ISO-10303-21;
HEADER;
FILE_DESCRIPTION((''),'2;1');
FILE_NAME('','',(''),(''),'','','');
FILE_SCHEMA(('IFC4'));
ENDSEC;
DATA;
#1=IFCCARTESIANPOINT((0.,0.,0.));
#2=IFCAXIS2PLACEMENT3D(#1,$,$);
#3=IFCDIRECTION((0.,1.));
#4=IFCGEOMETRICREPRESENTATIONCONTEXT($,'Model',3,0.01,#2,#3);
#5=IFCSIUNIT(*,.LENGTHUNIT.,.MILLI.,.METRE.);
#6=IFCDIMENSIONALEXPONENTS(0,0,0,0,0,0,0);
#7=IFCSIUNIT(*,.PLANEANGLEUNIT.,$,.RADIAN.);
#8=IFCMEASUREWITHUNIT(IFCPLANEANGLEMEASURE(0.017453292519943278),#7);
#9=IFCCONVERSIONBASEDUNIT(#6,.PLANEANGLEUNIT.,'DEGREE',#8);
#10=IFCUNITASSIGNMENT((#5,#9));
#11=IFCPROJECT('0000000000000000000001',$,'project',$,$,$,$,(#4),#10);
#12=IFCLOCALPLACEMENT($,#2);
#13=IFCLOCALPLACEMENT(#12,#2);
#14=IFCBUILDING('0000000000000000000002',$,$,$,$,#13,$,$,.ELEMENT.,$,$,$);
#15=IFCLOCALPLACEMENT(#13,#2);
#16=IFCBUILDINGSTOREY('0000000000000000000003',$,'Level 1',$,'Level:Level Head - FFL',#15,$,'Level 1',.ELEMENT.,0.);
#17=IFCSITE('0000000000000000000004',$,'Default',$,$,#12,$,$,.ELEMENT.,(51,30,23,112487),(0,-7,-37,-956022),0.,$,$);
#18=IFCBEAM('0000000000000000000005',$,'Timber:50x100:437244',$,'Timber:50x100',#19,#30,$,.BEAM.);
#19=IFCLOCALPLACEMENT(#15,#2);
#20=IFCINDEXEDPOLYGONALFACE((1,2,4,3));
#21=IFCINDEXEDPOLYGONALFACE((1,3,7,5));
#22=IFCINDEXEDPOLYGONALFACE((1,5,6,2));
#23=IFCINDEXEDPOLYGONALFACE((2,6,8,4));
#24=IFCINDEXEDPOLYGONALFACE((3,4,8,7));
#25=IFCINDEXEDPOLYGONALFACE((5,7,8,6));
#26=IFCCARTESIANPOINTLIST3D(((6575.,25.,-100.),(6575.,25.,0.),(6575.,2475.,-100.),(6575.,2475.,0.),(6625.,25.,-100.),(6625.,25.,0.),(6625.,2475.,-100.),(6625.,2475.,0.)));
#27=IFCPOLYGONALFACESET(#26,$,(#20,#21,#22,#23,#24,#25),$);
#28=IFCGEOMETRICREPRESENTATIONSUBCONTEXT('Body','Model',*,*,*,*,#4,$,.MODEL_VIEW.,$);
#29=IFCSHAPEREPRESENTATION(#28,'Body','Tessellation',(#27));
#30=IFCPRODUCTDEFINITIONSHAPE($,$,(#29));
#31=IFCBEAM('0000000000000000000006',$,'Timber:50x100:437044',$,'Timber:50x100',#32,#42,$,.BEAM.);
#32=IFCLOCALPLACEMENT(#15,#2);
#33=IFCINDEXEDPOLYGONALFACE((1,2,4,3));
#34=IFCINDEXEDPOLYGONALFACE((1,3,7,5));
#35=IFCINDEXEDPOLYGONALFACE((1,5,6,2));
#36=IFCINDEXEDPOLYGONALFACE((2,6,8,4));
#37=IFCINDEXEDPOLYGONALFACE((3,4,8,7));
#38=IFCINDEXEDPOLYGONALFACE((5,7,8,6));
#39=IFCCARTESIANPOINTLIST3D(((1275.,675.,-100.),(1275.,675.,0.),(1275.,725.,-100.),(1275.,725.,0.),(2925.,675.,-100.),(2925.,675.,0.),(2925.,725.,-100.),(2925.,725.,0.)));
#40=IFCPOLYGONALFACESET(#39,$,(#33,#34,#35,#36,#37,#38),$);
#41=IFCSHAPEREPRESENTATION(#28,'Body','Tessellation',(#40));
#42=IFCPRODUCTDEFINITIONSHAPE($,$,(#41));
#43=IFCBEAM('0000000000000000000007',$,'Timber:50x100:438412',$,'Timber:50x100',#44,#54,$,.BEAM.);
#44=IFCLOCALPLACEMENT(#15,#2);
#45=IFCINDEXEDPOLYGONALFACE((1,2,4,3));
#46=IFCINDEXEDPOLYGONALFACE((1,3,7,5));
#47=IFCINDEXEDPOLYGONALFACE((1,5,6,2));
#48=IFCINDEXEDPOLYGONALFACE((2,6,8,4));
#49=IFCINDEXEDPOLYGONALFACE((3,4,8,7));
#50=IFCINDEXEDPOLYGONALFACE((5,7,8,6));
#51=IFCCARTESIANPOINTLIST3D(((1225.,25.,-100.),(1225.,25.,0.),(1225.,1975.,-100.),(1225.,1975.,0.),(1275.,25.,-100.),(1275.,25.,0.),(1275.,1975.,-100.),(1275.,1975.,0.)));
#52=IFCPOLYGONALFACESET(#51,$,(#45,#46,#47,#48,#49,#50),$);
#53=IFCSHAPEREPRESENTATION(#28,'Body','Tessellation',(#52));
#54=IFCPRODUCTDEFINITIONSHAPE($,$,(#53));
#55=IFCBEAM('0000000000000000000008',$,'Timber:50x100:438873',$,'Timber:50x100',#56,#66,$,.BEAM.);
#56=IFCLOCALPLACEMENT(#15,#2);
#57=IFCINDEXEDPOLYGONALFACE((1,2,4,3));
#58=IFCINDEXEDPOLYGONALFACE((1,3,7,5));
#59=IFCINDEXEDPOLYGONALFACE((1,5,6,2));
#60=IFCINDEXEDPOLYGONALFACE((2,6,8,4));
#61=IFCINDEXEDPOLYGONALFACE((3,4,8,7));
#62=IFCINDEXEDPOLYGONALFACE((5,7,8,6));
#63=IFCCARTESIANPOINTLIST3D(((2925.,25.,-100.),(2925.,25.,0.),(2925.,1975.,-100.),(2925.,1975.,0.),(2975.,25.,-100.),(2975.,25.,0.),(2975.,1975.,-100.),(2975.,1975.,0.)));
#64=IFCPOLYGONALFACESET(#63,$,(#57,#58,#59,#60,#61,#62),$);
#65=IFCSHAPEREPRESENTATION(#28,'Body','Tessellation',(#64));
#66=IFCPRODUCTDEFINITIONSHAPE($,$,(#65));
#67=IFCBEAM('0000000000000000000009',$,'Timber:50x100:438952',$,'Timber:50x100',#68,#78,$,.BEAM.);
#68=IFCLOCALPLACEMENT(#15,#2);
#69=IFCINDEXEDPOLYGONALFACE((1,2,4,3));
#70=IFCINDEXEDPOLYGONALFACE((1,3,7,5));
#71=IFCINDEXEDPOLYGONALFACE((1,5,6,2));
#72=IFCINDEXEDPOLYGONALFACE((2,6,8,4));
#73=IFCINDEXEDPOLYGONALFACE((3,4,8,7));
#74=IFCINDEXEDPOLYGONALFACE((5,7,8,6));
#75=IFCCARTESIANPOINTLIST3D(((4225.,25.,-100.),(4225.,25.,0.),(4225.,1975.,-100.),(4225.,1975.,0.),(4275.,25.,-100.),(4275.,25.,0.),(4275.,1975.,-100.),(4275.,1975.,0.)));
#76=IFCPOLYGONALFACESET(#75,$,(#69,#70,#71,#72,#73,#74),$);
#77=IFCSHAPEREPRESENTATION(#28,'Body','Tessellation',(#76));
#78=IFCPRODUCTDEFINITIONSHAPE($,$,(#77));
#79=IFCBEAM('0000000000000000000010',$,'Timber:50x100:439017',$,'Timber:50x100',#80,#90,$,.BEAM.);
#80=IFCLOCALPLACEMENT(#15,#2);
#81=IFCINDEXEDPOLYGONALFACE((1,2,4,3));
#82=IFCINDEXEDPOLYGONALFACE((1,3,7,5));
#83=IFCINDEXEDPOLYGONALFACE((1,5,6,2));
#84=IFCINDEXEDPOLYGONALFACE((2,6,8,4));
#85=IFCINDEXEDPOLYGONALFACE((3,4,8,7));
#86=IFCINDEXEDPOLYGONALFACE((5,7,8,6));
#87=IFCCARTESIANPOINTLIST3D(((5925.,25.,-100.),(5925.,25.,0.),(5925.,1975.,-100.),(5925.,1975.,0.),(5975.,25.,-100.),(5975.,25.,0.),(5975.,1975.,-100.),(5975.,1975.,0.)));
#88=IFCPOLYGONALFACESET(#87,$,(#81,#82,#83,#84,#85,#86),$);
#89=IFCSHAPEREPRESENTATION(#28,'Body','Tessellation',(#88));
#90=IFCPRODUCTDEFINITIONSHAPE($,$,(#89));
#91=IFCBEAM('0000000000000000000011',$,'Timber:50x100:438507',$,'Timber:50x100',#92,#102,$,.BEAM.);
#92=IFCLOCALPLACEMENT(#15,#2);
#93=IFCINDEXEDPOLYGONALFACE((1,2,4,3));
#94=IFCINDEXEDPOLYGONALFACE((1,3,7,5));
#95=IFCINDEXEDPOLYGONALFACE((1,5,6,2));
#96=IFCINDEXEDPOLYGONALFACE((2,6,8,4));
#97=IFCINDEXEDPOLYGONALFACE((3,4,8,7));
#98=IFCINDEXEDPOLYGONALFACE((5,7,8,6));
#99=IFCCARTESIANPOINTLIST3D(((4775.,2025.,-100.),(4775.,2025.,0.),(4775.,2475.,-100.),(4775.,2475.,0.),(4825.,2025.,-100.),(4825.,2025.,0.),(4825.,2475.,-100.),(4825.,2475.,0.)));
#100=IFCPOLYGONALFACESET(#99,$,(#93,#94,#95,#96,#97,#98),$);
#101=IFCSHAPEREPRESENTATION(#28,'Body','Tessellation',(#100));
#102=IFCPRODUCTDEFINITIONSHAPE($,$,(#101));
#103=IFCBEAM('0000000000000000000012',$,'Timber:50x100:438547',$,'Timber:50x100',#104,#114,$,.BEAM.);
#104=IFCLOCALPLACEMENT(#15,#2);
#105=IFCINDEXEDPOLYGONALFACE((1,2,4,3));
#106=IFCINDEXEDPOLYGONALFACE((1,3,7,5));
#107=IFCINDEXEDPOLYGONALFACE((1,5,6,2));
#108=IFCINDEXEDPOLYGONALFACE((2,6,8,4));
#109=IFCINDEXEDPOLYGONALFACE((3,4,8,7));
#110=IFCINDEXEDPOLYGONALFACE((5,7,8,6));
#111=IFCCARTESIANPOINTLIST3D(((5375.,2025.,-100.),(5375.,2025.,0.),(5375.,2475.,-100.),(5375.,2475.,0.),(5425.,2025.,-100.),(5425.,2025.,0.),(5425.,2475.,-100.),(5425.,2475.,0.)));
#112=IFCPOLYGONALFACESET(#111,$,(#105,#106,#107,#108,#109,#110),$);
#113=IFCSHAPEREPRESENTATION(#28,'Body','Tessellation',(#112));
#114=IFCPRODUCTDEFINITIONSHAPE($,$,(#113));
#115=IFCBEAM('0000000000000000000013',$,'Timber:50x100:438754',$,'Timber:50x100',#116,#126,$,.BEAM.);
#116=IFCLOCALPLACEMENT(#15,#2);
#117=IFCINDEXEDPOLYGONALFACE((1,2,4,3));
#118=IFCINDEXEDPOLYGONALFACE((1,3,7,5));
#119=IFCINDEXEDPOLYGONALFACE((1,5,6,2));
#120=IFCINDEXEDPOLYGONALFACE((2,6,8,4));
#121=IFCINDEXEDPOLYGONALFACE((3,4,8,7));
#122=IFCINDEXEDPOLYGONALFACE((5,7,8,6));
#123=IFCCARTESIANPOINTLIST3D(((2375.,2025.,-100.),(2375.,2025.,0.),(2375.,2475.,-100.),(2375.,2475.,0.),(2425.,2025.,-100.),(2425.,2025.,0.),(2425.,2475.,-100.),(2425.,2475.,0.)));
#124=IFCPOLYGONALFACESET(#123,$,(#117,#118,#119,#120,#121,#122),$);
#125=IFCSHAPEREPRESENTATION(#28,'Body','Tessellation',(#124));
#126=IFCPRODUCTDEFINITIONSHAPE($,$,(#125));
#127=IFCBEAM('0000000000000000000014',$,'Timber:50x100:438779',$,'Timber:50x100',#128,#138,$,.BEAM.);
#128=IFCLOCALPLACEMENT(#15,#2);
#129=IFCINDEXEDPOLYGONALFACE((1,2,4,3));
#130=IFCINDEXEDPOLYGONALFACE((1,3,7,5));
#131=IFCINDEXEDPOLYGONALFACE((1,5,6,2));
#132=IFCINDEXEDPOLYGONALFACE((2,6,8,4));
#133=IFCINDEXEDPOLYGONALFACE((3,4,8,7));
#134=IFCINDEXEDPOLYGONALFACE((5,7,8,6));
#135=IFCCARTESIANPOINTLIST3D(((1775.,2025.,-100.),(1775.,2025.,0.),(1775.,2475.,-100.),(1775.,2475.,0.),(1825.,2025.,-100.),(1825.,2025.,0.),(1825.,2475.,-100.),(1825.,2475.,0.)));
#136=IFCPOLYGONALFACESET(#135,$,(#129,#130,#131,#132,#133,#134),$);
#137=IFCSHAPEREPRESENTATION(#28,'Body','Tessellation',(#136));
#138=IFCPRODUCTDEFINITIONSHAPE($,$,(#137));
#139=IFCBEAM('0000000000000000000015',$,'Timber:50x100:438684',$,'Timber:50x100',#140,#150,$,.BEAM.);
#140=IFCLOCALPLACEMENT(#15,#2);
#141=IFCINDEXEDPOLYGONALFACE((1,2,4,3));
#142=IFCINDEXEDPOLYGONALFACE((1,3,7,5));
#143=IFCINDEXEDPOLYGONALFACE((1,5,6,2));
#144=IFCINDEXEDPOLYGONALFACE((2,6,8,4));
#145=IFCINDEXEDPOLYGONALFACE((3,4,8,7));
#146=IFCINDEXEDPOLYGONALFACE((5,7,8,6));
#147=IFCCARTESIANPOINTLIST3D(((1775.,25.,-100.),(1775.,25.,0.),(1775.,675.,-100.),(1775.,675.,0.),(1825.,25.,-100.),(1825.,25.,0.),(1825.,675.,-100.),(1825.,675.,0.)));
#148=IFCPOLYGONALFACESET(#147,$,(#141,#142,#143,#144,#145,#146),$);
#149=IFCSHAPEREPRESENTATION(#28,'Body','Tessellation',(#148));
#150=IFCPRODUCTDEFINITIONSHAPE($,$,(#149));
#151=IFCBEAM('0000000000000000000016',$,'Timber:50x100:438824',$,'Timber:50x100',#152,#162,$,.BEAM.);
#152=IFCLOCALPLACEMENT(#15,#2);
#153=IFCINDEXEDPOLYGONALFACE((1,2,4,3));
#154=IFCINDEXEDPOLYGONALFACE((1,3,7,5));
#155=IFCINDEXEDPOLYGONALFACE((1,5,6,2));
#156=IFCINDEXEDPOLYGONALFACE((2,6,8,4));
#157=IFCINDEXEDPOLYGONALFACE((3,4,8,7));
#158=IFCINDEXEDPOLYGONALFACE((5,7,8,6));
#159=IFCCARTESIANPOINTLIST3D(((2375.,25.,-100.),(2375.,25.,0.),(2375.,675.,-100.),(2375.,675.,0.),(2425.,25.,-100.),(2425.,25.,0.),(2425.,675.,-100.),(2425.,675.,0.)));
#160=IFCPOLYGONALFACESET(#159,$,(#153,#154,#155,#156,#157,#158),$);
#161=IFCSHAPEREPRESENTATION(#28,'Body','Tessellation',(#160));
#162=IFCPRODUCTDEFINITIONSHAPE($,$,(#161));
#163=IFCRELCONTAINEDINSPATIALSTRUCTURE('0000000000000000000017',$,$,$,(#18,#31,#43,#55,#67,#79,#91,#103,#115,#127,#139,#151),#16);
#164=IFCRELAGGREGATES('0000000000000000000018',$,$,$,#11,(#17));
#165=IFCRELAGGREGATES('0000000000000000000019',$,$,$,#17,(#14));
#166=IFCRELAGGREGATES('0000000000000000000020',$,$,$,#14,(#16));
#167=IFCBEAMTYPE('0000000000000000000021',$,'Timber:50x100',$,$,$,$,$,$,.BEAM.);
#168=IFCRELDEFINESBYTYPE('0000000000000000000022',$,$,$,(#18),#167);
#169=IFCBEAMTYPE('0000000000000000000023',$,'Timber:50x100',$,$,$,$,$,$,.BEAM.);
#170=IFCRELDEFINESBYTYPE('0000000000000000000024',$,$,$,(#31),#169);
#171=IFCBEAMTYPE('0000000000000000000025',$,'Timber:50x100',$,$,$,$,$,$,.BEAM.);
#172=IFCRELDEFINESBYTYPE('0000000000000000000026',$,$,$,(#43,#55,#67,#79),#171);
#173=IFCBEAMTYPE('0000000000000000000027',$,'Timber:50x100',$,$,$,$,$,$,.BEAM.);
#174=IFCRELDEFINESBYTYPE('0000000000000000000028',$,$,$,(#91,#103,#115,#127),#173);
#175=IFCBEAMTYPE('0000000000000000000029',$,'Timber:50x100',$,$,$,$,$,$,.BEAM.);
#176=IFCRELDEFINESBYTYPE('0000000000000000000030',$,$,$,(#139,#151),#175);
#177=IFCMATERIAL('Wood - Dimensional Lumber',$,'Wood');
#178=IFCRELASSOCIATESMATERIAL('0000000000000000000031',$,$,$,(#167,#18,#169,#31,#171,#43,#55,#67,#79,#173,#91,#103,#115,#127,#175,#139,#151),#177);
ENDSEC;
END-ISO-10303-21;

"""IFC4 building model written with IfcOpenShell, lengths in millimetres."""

from ifc_helpers import new_model, entity, si_unit, converted_unit, direction, frame, origin, place, context, subcontext, project, spatial, indexed_curve, outline, extrude, source, transform, mapped, material, type_object, type_shapes, element, save


model = new_model("IFC4")

# Units and contexts
model_context = context("Model", 3, precision=0.01, world=origin(), true_north=direction((0.0, 1.0)))
body_context = subcontext(model_context, "Body", "Model", "MODEL_VIEW")
ifc_project = project(units=[si_unit("LENGTHUNIT", "METRE", prefix="MILLI"), converted_unit("PLANEANGLEUNIT", "DEGREE", entity("IfcPlaneAngleMeasure", 0.017453292519943278), si_unit("PLANEANGLEUNIT", "RADIAN"), dimensions=[0, 0, 0, 0, 0, 0, 0])], contexts=[model_context])

# Site, building, storey
site_placement = place(None, origin())
site = spatial("IfcSite", under=ifc_project, at=site_placement, Name="Default", CompositionType="ELEMENT", RefLatitude=(51, 30, 23, 112487), RefLongitude=(0, -7, -37, -956022), RefElevation=0.0)
building_placement = place(site_placement, origin())
building = spatial("IfcBuilding", under=site, at=building_placement, CompositionType="ELEMENT")
storey_placement = place(building_placement, origin())
storey = spatial("IfcBuildingStorey", under=building, at=storey_placement, Name="Level 1", ObjectType="Level:Level Head - FFL", LongName="Level 1", CompositionType="ELEMENT", Elevation=0.0)

# Beams
ifc_material = material(Name="Wood - Dimensional Lumber", Category="Wood")
beam_type_1 = type_object("IfcBeamType", Name="Timber:50x100", PredefinedType="BEAM", material=ifc_material)
shared_shape_1 = source(origin(), body_context, "Body", "SweptSolid", [
    extrude(outline(indexed_curve([(-1225.0, -25.0), (1225.0, -25.0), (1225.0, 25.0), (-1225.0, 25.0), (-1225.0, -25.0)], self_intersect=False)), frame((0.0, 0.0, -50.0), z_axis=(0.0, 0.0, 1.0), x_axis=(-1.0, 0.0, 0.0)), (0.0, 0.0, 1.0), 100.0),
])
type_shapes(beam_type_1, [shared_shape_1])
for number, where, z_axis, x_axis, name in (
    (1, (6600.0, 1250.0, -50.0), (0.0, 0.0, 1.0), (0.0, -1.0, 0.0), "Timber:50x100:437244"),
):
    element("IfcBeam", number, at=place(storey_placement, frame(where, z_axis=z_axis, x_axis=x_axis)), inside=storey, type_object=beam_type_1, material=ifc_material, Name=name, ObjectType="Timber:50x100", PredefinedType="BEAM", context=body_context, shape_type="MappedRepresentation", body=[
        mapped(shared_shape_1, transform((0.0, 0.0, 0.0), scale=1.0)),
    ])
beam_type_2 = type_object("IfcBeamType", Name="Timber:50x100", PredefinedType="BEAM", material=ifc_material)
shared_shape_2 = source(origin(), body_context, "Body", "SweptSolid", [
    extrude(outline(indexed_curve([(-825.0, -25.0), (825.0, -25.0), (825.0, 25.0), (-825.0, 25.0), (-825.0, -25.0)], self_intersect=False)), frame((0.0, 0.0, -50.0), z_axis=(0.0, 0.0, 1.0), x_axis=(-1.0, 0.0, 0.0)), (0.0, 0.0, 1.0), 100.0),
])
type_shapes(beam_type_2, [shared_shape_2])
beam_placement = place(storey_placement, frame((2100.0, 700.0, -50.0)))
element("IfcBeam", 2, at=beam_placement, inside=storey, type_object=beam_type_2, material=ifc_material, Name="Timber:50x100:437044", ObjectType="Timber:50x100", PredefinedType="BEAM", context=body_context, shape_type="MappedRepresentation", body=[
    mapped(shared_shape_2, transform((0.0, 0.0, 0.0), scale=1.0)),
])
beam_type_3 = type_object("IfcBeamType", Name="Timber:50x100", PredefinedType="BEAM", material=ifc_material)
shared_shape_3 = source(origin(), body_context, "Body", "SweptSolid", [
    extrude(outline(indexed_curve([(-975.0, -25.0), (975.0, -25.0), (975.0, 25.0), (-975.0, 25.0), (-975.0, -25.0)], self_intersect=False)), frame((0.0, 0.0, -50.0), z_axis=(0.0, 0.0, 1.0), x_axis=(-1.0, 0.0, 0.0)), (0.0, 0.0, 1.0), 100.0),
])
type_shapes(beam_type_3, [shared_shape_3])
for number, where, z_axis, x_axis, name in (
    (3, (1250.0, 1000.0, -50.0), (0.0, 0.0, 1.0), (0.0, 1.0, 0.0), "Timber:50x100:438412"),
    (4, (2950.0, 1000.0, -50.0), (0.0, 0.0, 1.0), (0.0, 1.0, 0.0), "Timber:50x100:438873"),
    (5, (4250.0, 1000.0, -50.0), (0.0, 0.0, 1.0), (0.0, 1.0, 0.0), "Timber:50x100:438952"),
    (6, (5950.0, 1000.0, -50.0), (0.0, 0.0, 1.0), (0.0, 1.0, 0.0), "Timber:50x100:439017"),
):
    element("IfcBeam", number, at=place(storey_placement, frame(where, z_axis=z_axis, x_axis=x_axis)), inside=storey, type_object=beam_type_3, material=ifc_material, Name=name, ObjectType="Timber:50x100", PredefinedType="BEAM", context=body_context, shape_type="MappedRepresentation", body=[
        mapped(shared_shape_3, transform((0.0, 0.0, 0.0), scale=1.0)),
    ])
beam_type_4 = type_object("IfcBeamType", Name="Timber:50x100", PredefinedType="BEAM", material=ifc_material)
shared_shape_4 = source(origin(), body_context, "Body", "SweptSolid", [
    extrude(outline(indexed_curve([(-225.0, -25.0), (225.0, -25.0), (225.0, 25.0), (-225.0, 25.0), (-225.0, -25.0)], self_intersect=False)), frame((0.0, 0.0, -50.0), z_axis=(0.0, 0.0, 1.0), x_axis=(-1.0, 0.0, 0.0)), (0.0, 0.0, 1.0), 100.0),
])
type_shapes(beam_type_4, [shared_shape_4])
for number, where, z_axis, x_axis, name in (
    (7, (4800.0, 2250.0, -50.0), (0.0, 0.0, 1.0), (0.0, -1.0, 0.0), "Timber:50x100:438507"),
    (8, (5400.0, 2250.0, -50.0), (0.0, 0.0, 1.0), (0.0, -1.0, 0.0), "Timber:50x100:438547"),
    (9, (2400.0, 2250.0, -50.0), (0.0, 0.0, 1.0), (0.0, -1.0, 0.0), "Timber:50x100:438754"),
    (10, (1800.0, 2250.0, -50.0), (0.0, 0.0, 1.0), (0.0, -1.0, 0.0), "Timber:50x100:438779"),
):
    element("IfcBeam", number, at=place(storey_placement, frame(where, z_axis=z_axis, x_axis=x_axis)), inside=storey, type_object=beam_type_4, material=ifc_material, Name=name, ObjectType="Timber:50x100", PredefinedType="BEAM", context=body_context, shape_type="MappedRepresentation", body=[
        mapped(shared_shape_4, transform((0.0, 0.0, 0.0), scale=1.0)),
    ])
beam_type_5 = type_object("IfcBeamType", Name="Timber:50x100", PredefinedType="BEAM", material=ifc_material)
shared_shape_5 = source(origin(), body_context, "Body", "SweptSolid", [
    extrude(outline(indexed_curve([(-325.0, -25.0), (325.0, -25.0), (325.0, 25.0), (-325.0, 25.0), (-325.0, -25.0)], self_intersect=False)), frame((0.0, 0.0, -50.0), z_axis=(0.0, 0.0, 1.0), x_axis=(-1.0, 0.0, 0.0)), (0.0, 0.0, 1.0), 100.0),
])
type_shapes(beam_type_5, [shared_shape_5])
for number, where, z_axis, x_axis, name in (
    (11, (1800.0, 350.0, -50.0), (0.0, 0.0, 1.0), (0.0, -1.0, 0.0), "Timber:50x100:438684"),
    (12, (2400.0, 350.0, -50.0), (0.0, 0.0, 1.0), (0.0, -1.0, 0.0), "Timber:50x100:438824"),
):
    element("IfcBeam", number, at=place(storey_placement, frame(where, z_axis=z_axis, x_axis=x_axis)), inside=storey, type_object=beam_type_5, material=ifc_material, Name=name, ObjectType="Timber:50x100", PredefinedType="BEAM", context=body_context, shape_type="MappedRepresentation", body=[
        mapped(shared_shape_5, transform((0.0, 0.0, 0.0), scale=1.0)),
    ])

save(model, "model.ifc")
